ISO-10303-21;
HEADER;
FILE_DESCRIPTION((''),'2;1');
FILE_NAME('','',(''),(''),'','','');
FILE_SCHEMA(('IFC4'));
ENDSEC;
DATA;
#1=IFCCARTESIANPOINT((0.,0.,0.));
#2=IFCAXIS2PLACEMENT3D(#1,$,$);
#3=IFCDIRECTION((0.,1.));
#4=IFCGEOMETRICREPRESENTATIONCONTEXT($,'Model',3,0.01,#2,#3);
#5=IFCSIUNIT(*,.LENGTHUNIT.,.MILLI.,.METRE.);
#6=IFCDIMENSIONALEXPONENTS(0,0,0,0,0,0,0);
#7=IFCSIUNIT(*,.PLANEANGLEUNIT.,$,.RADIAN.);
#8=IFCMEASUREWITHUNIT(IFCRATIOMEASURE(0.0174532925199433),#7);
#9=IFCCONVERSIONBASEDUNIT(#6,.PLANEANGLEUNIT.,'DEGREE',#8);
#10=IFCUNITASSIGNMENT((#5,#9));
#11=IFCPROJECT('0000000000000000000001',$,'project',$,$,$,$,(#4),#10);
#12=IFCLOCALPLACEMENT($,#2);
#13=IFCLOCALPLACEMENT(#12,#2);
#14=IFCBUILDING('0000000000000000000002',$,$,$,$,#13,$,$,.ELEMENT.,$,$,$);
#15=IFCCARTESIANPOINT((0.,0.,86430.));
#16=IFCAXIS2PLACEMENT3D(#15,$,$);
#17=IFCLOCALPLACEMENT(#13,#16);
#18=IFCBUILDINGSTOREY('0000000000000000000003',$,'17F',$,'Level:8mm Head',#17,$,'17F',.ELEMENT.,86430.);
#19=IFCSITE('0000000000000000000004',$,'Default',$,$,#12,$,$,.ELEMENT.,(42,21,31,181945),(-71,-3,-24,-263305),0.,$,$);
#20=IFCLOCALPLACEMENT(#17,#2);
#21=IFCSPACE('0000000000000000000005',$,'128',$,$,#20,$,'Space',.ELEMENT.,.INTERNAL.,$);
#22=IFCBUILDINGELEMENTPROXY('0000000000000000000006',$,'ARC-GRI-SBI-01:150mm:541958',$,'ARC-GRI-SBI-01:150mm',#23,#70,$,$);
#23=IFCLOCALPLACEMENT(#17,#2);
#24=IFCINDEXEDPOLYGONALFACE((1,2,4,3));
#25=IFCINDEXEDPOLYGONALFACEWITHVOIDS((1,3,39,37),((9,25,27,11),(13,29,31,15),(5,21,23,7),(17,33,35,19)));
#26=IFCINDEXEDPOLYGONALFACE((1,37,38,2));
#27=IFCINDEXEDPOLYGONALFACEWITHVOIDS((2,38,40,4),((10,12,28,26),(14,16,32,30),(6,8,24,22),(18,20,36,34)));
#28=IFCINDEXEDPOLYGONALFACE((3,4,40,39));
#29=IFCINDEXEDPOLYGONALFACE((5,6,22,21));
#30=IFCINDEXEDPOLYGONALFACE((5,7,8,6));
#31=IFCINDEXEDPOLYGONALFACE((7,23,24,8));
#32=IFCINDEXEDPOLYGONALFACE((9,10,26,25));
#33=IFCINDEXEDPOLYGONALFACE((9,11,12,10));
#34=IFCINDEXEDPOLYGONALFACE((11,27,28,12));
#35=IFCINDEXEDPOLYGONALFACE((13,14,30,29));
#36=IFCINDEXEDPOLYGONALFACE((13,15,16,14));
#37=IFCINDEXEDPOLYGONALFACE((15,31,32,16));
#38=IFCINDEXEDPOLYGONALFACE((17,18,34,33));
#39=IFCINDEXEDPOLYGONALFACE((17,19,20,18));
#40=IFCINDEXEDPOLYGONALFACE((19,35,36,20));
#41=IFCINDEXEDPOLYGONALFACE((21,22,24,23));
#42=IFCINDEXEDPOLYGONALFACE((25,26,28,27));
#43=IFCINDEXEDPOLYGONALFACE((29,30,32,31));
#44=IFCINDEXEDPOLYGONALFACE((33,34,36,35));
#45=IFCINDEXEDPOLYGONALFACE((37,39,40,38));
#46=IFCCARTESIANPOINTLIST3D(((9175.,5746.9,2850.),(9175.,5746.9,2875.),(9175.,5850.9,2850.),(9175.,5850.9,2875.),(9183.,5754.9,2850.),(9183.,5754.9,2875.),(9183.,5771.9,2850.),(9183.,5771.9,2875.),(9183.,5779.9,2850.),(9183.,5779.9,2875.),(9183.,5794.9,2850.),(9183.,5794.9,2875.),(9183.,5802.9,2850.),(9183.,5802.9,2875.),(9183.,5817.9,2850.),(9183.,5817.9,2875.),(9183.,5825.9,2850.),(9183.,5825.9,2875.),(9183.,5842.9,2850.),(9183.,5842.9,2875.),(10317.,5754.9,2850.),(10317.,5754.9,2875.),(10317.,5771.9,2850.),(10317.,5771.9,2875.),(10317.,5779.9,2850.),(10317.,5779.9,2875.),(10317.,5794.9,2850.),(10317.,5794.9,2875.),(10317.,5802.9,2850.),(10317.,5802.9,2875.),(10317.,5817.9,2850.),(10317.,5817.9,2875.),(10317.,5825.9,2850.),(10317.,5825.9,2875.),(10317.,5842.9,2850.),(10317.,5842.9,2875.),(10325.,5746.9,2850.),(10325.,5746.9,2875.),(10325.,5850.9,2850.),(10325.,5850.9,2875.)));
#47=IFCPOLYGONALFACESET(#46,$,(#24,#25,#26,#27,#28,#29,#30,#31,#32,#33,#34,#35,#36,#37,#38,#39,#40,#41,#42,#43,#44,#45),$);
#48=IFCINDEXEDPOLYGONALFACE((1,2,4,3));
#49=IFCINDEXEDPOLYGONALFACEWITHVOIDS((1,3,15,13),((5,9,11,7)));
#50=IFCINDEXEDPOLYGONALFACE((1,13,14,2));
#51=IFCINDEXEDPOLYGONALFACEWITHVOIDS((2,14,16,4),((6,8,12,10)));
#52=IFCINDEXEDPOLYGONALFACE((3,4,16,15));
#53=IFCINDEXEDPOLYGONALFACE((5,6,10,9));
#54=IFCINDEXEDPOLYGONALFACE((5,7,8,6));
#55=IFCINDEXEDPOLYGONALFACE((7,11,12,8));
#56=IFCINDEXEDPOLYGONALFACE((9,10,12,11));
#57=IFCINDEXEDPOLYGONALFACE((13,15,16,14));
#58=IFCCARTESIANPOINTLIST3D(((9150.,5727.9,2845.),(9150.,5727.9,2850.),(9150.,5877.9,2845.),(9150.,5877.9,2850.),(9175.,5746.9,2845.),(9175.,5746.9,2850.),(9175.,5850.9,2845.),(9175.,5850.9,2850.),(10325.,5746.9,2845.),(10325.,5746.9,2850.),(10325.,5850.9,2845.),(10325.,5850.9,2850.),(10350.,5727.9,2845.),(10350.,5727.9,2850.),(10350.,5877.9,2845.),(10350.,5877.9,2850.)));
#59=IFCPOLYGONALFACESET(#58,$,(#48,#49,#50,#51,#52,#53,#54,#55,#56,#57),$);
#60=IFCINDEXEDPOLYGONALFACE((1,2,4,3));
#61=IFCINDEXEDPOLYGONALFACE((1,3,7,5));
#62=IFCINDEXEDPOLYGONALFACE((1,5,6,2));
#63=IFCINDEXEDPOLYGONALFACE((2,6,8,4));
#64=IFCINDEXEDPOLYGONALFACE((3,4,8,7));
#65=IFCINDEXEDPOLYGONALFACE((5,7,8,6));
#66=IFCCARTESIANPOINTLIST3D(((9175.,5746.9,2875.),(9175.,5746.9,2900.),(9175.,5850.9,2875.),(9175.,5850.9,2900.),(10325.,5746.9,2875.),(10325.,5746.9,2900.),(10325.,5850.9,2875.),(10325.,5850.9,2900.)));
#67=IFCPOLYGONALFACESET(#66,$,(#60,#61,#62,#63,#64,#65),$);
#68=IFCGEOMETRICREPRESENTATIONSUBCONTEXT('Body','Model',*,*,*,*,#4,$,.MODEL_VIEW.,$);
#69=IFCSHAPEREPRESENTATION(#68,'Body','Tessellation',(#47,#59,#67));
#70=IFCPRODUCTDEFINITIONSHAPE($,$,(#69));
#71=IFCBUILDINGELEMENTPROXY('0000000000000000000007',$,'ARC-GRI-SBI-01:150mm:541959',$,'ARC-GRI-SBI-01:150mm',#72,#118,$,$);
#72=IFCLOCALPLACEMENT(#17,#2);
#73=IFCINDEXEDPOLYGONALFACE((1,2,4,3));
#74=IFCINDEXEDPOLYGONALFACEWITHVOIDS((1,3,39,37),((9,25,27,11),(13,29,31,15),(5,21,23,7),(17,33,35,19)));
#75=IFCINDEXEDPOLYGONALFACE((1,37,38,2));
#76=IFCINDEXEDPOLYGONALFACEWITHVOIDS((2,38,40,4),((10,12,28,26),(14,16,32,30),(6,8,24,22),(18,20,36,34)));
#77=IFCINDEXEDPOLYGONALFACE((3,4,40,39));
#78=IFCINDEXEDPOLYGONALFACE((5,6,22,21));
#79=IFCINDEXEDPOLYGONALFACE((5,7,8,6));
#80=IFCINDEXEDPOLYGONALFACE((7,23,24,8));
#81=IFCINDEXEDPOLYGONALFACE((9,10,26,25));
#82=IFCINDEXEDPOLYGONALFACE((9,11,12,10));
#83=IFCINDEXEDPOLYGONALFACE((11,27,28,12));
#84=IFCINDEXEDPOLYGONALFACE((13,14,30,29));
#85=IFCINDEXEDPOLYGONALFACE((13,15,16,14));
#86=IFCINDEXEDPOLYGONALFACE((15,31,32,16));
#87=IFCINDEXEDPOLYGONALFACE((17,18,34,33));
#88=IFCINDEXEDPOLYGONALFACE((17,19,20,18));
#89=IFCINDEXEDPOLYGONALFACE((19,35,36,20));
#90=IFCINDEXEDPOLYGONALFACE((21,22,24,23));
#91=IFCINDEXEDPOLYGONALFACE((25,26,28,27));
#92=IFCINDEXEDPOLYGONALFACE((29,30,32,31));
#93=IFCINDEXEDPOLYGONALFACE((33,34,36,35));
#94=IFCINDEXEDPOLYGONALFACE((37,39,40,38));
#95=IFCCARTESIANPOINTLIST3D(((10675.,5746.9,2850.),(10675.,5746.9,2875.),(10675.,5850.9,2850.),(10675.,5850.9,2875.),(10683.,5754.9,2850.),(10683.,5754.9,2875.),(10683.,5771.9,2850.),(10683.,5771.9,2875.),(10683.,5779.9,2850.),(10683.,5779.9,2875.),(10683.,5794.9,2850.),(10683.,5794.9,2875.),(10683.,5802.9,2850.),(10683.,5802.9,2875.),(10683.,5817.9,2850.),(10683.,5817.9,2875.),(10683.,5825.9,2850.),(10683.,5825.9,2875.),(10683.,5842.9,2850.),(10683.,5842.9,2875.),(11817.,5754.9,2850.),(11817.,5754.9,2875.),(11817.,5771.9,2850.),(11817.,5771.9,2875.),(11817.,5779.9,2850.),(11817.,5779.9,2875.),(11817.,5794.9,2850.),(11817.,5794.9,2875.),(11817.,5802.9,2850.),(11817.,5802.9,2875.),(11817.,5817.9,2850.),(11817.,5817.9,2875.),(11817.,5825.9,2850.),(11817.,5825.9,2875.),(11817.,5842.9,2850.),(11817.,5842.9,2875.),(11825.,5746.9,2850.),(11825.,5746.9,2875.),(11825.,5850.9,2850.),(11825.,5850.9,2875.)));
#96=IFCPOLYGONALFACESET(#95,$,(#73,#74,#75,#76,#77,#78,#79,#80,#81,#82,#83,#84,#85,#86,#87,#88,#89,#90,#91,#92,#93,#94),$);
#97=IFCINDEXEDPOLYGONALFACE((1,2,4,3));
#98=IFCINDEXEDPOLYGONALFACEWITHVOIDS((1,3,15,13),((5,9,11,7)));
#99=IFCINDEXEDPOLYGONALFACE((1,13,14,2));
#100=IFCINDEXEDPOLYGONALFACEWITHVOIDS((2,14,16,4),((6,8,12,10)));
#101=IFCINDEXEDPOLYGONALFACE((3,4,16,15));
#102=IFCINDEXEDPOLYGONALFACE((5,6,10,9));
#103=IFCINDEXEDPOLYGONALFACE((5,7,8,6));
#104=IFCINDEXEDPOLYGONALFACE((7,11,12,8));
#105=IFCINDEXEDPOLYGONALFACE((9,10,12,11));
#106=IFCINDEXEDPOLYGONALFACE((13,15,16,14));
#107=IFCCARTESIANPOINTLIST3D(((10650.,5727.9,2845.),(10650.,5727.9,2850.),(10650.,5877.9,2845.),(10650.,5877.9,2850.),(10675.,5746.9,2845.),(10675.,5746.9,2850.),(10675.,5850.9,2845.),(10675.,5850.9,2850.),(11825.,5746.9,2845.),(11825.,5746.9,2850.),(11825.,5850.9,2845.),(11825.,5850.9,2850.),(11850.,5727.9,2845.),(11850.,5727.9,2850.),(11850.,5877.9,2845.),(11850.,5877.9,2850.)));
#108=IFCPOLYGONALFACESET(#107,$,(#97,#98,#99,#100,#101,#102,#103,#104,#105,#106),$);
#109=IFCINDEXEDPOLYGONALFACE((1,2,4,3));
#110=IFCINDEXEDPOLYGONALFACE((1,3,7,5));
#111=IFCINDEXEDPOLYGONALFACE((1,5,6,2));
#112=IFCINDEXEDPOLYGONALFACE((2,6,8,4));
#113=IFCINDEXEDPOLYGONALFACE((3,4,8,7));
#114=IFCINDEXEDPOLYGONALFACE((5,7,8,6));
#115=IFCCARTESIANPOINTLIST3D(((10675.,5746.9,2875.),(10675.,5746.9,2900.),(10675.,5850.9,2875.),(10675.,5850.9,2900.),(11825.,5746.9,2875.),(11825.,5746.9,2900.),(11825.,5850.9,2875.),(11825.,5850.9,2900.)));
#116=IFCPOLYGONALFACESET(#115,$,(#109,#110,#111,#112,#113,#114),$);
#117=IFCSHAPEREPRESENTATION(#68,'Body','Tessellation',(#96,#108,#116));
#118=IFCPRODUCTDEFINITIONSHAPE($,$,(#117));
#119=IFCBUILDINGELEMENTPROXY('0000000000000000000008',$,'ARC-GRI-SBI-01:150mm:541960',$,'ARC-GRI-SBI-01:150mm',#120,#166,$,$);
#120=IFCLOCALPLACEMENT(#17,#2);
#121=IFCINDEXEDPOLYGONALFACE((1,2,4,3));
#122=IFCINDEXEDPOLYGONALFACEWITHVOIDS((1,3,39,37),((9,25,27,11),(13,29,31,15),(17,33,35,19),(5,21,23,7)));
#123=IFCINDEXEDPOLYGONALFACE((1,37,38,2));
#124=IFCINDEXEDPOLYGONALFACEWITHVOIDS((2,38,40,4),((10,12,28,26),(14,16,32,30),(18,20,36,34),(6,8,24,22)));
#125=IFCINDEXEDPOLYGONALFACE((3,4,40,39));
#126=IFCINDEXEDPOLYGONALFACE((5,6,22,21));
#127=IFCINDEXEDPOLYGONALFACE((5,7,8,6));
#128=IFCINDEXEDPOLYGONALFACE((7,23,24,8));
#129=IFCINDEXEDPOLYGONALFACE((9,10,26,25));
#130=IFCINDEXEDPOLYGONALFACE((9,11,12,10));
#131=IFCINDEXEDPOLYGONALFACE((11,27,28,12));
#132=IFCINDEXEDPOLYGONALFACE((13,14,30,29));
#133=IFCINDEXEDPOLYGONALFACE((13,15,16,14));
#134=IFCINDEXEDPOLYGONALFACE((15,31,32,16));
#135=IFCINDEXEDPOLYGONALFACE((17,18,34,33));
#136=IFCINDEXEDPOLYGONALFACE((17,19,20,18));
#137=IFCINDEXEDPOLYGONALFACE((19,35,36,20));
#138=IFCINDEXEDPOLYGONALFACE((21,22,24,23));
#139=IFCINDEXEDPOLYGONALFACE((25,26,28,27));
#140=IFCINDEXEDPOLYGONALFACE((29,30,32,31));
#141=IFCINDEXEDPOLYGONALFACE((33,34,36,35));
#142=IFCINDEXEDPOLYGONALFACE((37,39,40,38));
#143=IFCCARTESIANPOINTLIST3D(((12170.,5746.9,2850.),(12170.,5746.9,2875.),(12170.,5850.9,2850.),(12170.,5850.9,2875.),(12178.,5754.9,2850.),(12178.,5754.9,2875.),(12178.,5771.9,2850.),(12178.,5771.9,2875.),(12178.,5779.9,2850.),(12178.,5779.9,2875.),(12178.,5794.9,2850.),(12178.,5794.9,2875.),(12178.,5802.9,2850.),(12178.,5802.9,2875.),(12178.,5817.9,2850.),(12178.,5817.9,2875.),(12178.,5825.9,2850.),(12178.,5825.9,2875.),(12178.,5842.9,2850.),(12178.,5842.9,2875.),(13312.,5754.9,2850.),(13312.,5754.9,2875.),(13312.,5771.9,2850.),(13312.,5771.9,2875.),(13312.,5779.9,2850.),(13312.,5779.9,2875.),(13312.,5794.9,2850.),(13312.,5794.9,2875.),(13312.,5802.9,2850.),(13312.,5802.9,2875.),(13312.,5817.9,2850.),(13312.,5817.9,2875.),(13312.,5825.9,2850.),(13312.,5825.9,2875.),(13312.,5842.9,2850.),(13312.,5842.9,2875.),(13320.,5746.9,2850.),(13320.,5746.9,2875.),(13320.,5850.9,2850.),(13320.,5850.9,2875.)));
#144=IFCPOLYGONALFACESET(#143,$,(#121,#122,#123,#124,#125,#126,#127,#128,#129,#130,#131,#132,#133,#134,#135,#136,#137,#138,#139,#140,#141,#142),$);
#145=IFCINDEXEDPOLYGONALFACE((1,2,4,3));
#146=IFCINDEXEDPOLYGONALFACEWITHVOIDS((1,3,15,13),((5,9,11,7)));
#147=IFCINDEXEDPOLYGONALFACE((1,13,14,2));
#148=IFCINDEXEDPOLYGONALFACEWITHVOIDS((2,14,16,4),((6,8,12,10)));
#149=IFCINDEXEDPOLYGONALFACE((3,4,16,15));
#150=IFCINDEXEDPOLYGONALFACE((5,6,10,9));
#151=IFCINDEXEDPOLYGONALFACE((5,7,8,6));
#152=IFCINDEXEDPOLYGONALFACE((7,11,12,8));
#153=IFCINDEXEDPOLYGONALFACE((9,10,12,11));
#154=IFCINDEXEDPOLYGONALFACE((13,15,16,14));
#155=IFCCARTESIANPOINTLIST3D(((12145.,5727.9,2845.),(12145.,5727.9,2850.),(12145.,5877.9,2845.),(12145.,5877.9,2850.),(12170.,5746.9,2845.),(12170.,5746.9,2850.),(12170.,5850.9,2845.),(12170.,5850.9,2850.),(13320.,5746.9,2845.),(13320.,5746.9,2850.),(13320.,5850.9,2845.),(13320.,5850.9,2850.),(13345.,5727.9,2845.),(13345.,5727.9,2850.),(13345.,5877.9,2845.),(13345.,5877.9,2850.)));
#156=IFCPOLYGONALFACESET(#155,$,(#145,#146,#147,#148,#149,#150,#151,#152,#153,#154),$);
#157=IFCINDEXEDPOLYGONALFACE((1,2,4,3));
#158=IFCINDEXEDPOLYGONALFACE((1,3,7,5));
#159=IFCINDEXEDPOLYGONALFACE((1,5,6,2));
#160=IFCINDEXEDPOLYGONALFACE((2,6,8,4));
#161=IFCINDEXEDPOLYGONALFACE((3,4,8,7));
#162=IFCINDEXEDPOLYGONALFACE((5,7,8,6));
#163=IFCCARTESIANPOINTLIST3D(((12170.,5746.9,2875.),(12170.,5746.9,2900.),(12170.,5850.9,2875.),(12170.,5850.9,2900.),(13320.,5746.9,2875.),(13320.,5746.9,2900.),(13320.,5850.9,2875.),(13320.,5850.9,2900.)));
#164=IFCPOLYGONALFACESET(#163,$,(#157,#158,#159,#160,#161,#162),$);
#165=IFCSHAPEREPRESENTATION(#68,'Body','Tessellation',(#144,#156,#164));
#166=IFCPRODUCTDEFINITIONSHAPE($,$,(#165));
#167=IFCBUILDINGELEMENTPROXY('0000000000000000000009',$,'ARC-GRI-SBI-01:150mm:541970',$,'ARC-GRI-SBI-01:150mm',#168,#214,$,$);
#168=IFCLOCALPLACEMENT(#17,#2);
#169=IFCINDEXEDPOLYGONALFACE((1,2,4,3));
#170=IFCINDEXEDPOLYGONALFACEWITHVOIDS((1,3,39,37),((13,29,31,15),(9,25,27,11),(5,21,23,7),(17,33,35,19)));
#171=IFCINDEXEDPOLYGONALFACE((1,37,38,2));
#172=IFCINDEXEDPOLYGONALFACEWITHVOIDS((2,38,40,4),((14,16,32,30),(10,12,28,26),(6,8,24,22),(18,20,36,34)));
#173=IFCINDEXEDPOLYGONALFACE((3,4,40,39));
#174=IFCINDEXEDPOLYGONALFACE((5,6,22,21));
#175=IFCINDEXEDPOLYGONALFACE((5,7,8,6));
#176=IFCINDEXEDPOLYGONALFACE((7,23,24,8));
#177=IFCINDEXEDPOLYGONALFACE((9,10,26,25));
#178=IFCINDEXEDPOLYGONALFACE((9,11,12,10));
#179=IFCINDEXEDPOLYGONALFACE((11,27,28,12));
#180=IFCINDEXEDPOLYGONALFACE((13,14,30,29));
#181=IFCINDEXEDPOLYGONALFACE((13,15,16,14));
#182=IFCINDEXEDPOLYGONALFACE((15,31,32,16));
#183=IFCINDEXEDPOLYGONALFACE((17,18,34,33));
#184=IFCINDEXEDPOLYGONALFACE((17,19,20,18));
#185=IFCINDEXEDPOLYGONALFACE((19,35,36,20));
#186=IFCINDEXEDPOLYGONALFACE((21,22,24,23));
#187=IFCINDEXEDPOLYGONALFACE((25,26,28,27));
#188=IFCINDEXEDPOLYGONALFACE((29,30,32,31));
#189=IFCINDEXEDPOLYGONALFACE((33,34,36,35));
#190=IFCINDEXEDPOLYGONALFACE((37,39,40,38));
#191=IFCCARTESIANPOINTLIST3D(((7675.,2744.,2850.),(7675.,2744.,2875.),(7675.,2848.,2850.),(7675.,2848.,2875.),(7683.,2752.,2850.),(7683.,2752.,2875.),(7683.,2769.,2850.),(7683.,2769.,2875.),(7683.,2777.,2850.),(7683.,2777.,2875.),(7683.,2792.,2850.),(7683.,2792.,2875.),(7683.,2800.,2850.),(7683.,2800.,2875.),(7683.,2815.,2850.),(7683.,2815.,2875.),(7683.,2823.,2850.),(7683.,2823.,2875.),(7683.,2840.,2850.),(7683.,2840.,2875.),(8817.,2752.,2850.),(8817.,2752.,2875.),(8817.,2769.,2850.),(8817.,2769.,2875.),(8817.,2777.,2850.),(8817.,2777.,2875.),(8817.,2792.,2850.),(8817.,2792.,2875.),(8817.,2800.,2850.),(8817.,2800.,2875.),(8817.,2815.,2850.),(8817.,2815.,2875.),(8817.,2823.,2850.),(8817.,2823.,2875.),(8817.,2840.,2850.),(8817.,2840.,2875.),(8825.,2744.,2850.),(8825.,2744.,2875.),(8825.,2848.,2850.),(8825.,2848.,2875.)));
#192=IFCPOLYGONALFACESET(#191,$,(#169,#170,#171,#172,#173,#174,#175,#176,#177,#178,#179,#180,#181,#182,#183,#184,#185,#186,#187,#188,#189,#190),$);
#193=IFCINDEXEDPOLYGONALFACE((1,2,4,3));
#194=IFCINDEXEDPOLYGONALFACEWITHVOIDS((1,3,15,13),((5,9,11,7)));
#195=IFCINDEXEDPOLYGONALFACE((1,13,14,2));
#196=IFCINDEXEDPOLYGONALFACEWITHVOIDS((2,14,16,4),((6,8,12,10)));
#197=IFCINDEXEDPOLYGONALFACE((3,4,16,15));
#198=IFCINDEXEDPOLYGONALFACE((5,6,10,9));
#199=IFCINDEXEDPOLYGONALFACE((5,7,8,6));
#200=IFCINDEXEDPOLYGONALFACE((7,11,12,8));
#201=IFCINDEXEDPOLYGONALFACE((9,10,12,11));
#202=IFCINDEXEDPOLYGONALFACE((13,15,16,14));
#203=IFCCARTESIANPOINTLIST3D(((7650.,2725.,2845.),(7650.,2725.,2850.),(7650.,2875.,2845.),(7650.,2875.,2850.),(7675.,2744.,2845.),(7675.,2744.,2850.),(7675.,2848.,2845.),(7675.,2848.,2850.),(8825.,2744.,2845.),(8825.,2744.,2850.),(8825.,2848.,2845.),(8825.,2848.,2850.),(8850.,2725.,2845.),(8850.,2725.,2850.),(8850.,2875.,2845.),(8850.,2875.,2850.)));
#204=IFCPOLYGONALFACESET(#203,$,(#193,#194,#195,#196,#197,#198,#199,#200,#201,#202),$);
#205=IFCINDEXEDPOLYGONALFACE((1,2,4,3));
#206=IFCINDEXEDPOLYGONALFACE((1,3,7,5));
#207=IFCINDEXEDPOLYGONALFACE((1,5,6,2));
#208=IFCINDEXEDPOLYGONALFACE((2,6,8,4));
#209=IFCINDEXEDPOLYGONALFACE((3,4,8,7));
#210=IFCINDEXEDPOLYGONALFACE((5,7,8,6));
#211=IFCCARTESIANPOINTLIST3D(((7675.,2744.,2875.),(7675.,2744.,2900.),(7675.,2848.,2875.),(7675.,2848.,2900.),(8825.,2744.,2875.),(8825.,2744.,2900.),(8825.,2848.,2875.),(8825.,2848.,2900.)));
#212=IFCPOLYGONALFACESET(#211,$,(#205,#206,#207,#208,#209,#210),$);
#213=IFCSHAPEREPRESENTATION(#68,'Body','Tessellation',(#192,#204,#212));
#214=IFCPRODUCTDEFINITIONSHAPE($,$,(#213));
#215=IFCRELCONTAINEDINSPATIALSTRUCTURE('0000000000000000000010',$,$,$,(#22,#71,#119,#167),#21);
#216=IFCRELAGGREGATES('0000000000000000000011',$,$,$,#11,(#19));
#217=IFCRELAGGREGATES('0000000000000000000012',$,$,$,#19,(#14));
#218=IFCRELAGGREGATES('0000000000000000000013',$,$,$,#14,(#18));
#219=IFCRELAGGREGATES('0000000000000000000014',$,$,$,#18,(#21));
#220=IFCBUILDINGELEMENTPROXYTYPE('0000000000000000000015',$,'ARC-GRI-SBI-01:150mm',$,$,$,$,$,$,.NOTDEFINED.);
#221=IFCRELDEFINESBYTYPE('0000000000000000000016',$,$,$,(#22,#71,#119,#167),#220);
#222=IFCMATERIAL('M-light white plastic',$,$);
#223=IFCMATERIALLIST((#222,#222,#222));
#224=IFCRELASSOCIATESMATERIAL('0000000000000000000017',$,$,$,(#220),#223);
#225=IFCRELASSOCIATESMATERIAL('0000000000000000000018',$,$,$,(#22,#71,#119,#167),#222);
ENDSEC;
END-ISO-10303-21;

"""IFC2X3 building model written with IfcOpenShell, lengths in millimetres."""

from ifc_helpers import new_model, entity, si_unit, converted_unit, direction, frame, origin, origin_2d_with_axis, place, context, subcontext, project, spatial, polyline, rectangle, outline, extrude, source, transform, mapped, material, material_list, type_object, type_shapes, element, save


model = new_model("IFC2X3")

# Units and contexts
model_context = context("Model", 3, precision=0.01, world=origin(), true_north=direction((0.0, 1.0)))
body_context = subcontext(model_context, "Body", "Model", "MODEL_VIEW")
ifc_project = project(units=[si_unit("LENGTHUNIT", "METRE", prefix="MILLI"), converted_unit("PLANEANGLEUNIT", "DEGREE", entity("IfcRatioMeasure", 0.0174532925199433), si_unit("PLANEANGLEUNIT", "RADIAN"), dimensions=[0, 0, 0, 0, 0, 0, 0])], contexts=[model_context])

# Site, building, storey
site_placement = place(None, origin())
site = spatial("IfcSite", under=ifc_project, at=site_placement, Name="Default", CompositionType="ELEMENT", RefLatitude=(42, 21, 31, 181945), RefLongitude=(-71, -3, -24, -263305), RefElevation=0.0)
building_placement = place(site_placement, origin())
building = spatial("IfcBuilding", under=site, at=building_placement, CompositionType="ELEMENT")
storey_placement = place(building_placement, frame((0.0, 0.0, 86430.0)))
storey = spatial("IfcBuildingStorey", under=building, at=storey_placement, Name="17F", ObjectType="Level:8mm Head", LongName="17F", CompositionType="ELEMENT", Elevation=86430.0)

# Shared definitions
space_placement = place(storey_placement, origin())
space = spatial("IfcSpace", under=storey, at=space_placement, Name="128", LongName="Space", CompositionType="ELEMENT", InteriorOrExteriorSpace="INTERNAL")

# Building element proxies
ifc_material_1 = material(Name="M-light white plastic")
ifc_material_list = material_list([ifc_material_1, ifc_material_1, ifc_material_1])
building_element_proxy_type = type_object("IfcBuildingElementProxyType", Name="ARC-GRI-SBI-01:150mm", PredefinedType="NOTDEFINED", material=ifc_material_list)
shared_shape = source(origin(), body_context, "Body", "SweptSolid", [
    extrude(outline(polyline([(-575.0, -52.0), (575.0, -52.0), (575.0, 52.0), (-575.0, 52.0), (-575.0, -52.0)]), holes=[polyline([(-567.0, -44.0), (-567.0, -27.0), (567.0, -27.0), (567.0, -44.0), (-567.0, -44.0)]), polyline([(567.0, -4.0), (567.0, -19.0), (-567.0, -19.0), (-567.0, -4.0), (567.0, -4.0)]), polyline([(-567.0, 44.0), (567.0, 44.0), (567.0, 27.0), (-567.0, 27.0), (-567.0, 44.0)]), polyline([(567.0, 4.0), (-567.0, 4.0), (-567.0, 19.0), (567.0, 19.0), (567.0, 4.0)])]), frame((425.0, 4.0, 4000.0), z_axis=(0.0, 0.0, 1.0), x_axis=(-1.0, 0.0, 0.0)), (0.0, 0.0, 1.0), 25.0),
    extrude(outline(polyline([(-600.0, -75.0), (600.0, -75.0), (600.0, 75.0), (-600.0, 75.0), (-600.0, -75.0)]), holes=[polyline([(-575.0, -56.0), (-575.0, 48.0), (575.0, 48.0), (575.0, -56.0), (-575.0, -56.0)])]), frame((425.0, 0.0, 3995.0), z_axis=(0.0, 0.0, 1.0), x_axis=(-1.0, 0.0, 0.0)), (0.0, 0.0, 1.0), 5.0),
    extrude(rectangle(XDim=1150.0, YDim=104.0, at=origin_2d_with_axis()), frame((425.0, 4.0, 4025.0), z_axis=(0.0, 0.0, 1.0), x_axis=(-1.0, 0.0, 0.0)), (0.0, 0.0, 1.0), 25.0),
])
type_shapes(building_element_proxy_type, [shared_shape])
for number, where, z_axis, x_axis, name in (
    (1, (10175.0, 5802.9, -1150.0), (0.0, 0.0, 1.0), (-1.0, 0.0, 0.0), "ARC-GRI-SBI-01:150mm:541958"),
    (2, (11675.0, 5802.9, -1150.0), (0.0, 0.0, 1.0), (-1.0, 0.0, 0.0), "ARC-GRI-SBI-01:150mm:541959"),
    (3, (13170.0, 5802.9, -1150.0), (0.0, 0.0, 1.0), (-1.0, 0.0, 0.0), "ARC-GRI-SBI-01:150mm:541960"),
    (4, (8675.0, 2800.0, -1150.0), (0.0, 0.0, 1.0), (-1.0, 0.0, 0.0), "ARC-GRI-SBI-01:150mm:541970"),
):
    element("IfcBuildingElementProxy", number, at=place(space_placement, frame(where, z_axis=z_axis, x_axis=x_axis)), inside=space, type_object=building_element_proxy_type, material=ifc_material_1, Name=name, ObjectType="ARC-GRI-SBI-01:150mm", context=body_context, shape_type="MappedRepresentation", body=[
        mapped(shared_shape, transform((0.0, 0.0, 0.0), scale=1.0)),
    ])

save(model, "model.ifc")
